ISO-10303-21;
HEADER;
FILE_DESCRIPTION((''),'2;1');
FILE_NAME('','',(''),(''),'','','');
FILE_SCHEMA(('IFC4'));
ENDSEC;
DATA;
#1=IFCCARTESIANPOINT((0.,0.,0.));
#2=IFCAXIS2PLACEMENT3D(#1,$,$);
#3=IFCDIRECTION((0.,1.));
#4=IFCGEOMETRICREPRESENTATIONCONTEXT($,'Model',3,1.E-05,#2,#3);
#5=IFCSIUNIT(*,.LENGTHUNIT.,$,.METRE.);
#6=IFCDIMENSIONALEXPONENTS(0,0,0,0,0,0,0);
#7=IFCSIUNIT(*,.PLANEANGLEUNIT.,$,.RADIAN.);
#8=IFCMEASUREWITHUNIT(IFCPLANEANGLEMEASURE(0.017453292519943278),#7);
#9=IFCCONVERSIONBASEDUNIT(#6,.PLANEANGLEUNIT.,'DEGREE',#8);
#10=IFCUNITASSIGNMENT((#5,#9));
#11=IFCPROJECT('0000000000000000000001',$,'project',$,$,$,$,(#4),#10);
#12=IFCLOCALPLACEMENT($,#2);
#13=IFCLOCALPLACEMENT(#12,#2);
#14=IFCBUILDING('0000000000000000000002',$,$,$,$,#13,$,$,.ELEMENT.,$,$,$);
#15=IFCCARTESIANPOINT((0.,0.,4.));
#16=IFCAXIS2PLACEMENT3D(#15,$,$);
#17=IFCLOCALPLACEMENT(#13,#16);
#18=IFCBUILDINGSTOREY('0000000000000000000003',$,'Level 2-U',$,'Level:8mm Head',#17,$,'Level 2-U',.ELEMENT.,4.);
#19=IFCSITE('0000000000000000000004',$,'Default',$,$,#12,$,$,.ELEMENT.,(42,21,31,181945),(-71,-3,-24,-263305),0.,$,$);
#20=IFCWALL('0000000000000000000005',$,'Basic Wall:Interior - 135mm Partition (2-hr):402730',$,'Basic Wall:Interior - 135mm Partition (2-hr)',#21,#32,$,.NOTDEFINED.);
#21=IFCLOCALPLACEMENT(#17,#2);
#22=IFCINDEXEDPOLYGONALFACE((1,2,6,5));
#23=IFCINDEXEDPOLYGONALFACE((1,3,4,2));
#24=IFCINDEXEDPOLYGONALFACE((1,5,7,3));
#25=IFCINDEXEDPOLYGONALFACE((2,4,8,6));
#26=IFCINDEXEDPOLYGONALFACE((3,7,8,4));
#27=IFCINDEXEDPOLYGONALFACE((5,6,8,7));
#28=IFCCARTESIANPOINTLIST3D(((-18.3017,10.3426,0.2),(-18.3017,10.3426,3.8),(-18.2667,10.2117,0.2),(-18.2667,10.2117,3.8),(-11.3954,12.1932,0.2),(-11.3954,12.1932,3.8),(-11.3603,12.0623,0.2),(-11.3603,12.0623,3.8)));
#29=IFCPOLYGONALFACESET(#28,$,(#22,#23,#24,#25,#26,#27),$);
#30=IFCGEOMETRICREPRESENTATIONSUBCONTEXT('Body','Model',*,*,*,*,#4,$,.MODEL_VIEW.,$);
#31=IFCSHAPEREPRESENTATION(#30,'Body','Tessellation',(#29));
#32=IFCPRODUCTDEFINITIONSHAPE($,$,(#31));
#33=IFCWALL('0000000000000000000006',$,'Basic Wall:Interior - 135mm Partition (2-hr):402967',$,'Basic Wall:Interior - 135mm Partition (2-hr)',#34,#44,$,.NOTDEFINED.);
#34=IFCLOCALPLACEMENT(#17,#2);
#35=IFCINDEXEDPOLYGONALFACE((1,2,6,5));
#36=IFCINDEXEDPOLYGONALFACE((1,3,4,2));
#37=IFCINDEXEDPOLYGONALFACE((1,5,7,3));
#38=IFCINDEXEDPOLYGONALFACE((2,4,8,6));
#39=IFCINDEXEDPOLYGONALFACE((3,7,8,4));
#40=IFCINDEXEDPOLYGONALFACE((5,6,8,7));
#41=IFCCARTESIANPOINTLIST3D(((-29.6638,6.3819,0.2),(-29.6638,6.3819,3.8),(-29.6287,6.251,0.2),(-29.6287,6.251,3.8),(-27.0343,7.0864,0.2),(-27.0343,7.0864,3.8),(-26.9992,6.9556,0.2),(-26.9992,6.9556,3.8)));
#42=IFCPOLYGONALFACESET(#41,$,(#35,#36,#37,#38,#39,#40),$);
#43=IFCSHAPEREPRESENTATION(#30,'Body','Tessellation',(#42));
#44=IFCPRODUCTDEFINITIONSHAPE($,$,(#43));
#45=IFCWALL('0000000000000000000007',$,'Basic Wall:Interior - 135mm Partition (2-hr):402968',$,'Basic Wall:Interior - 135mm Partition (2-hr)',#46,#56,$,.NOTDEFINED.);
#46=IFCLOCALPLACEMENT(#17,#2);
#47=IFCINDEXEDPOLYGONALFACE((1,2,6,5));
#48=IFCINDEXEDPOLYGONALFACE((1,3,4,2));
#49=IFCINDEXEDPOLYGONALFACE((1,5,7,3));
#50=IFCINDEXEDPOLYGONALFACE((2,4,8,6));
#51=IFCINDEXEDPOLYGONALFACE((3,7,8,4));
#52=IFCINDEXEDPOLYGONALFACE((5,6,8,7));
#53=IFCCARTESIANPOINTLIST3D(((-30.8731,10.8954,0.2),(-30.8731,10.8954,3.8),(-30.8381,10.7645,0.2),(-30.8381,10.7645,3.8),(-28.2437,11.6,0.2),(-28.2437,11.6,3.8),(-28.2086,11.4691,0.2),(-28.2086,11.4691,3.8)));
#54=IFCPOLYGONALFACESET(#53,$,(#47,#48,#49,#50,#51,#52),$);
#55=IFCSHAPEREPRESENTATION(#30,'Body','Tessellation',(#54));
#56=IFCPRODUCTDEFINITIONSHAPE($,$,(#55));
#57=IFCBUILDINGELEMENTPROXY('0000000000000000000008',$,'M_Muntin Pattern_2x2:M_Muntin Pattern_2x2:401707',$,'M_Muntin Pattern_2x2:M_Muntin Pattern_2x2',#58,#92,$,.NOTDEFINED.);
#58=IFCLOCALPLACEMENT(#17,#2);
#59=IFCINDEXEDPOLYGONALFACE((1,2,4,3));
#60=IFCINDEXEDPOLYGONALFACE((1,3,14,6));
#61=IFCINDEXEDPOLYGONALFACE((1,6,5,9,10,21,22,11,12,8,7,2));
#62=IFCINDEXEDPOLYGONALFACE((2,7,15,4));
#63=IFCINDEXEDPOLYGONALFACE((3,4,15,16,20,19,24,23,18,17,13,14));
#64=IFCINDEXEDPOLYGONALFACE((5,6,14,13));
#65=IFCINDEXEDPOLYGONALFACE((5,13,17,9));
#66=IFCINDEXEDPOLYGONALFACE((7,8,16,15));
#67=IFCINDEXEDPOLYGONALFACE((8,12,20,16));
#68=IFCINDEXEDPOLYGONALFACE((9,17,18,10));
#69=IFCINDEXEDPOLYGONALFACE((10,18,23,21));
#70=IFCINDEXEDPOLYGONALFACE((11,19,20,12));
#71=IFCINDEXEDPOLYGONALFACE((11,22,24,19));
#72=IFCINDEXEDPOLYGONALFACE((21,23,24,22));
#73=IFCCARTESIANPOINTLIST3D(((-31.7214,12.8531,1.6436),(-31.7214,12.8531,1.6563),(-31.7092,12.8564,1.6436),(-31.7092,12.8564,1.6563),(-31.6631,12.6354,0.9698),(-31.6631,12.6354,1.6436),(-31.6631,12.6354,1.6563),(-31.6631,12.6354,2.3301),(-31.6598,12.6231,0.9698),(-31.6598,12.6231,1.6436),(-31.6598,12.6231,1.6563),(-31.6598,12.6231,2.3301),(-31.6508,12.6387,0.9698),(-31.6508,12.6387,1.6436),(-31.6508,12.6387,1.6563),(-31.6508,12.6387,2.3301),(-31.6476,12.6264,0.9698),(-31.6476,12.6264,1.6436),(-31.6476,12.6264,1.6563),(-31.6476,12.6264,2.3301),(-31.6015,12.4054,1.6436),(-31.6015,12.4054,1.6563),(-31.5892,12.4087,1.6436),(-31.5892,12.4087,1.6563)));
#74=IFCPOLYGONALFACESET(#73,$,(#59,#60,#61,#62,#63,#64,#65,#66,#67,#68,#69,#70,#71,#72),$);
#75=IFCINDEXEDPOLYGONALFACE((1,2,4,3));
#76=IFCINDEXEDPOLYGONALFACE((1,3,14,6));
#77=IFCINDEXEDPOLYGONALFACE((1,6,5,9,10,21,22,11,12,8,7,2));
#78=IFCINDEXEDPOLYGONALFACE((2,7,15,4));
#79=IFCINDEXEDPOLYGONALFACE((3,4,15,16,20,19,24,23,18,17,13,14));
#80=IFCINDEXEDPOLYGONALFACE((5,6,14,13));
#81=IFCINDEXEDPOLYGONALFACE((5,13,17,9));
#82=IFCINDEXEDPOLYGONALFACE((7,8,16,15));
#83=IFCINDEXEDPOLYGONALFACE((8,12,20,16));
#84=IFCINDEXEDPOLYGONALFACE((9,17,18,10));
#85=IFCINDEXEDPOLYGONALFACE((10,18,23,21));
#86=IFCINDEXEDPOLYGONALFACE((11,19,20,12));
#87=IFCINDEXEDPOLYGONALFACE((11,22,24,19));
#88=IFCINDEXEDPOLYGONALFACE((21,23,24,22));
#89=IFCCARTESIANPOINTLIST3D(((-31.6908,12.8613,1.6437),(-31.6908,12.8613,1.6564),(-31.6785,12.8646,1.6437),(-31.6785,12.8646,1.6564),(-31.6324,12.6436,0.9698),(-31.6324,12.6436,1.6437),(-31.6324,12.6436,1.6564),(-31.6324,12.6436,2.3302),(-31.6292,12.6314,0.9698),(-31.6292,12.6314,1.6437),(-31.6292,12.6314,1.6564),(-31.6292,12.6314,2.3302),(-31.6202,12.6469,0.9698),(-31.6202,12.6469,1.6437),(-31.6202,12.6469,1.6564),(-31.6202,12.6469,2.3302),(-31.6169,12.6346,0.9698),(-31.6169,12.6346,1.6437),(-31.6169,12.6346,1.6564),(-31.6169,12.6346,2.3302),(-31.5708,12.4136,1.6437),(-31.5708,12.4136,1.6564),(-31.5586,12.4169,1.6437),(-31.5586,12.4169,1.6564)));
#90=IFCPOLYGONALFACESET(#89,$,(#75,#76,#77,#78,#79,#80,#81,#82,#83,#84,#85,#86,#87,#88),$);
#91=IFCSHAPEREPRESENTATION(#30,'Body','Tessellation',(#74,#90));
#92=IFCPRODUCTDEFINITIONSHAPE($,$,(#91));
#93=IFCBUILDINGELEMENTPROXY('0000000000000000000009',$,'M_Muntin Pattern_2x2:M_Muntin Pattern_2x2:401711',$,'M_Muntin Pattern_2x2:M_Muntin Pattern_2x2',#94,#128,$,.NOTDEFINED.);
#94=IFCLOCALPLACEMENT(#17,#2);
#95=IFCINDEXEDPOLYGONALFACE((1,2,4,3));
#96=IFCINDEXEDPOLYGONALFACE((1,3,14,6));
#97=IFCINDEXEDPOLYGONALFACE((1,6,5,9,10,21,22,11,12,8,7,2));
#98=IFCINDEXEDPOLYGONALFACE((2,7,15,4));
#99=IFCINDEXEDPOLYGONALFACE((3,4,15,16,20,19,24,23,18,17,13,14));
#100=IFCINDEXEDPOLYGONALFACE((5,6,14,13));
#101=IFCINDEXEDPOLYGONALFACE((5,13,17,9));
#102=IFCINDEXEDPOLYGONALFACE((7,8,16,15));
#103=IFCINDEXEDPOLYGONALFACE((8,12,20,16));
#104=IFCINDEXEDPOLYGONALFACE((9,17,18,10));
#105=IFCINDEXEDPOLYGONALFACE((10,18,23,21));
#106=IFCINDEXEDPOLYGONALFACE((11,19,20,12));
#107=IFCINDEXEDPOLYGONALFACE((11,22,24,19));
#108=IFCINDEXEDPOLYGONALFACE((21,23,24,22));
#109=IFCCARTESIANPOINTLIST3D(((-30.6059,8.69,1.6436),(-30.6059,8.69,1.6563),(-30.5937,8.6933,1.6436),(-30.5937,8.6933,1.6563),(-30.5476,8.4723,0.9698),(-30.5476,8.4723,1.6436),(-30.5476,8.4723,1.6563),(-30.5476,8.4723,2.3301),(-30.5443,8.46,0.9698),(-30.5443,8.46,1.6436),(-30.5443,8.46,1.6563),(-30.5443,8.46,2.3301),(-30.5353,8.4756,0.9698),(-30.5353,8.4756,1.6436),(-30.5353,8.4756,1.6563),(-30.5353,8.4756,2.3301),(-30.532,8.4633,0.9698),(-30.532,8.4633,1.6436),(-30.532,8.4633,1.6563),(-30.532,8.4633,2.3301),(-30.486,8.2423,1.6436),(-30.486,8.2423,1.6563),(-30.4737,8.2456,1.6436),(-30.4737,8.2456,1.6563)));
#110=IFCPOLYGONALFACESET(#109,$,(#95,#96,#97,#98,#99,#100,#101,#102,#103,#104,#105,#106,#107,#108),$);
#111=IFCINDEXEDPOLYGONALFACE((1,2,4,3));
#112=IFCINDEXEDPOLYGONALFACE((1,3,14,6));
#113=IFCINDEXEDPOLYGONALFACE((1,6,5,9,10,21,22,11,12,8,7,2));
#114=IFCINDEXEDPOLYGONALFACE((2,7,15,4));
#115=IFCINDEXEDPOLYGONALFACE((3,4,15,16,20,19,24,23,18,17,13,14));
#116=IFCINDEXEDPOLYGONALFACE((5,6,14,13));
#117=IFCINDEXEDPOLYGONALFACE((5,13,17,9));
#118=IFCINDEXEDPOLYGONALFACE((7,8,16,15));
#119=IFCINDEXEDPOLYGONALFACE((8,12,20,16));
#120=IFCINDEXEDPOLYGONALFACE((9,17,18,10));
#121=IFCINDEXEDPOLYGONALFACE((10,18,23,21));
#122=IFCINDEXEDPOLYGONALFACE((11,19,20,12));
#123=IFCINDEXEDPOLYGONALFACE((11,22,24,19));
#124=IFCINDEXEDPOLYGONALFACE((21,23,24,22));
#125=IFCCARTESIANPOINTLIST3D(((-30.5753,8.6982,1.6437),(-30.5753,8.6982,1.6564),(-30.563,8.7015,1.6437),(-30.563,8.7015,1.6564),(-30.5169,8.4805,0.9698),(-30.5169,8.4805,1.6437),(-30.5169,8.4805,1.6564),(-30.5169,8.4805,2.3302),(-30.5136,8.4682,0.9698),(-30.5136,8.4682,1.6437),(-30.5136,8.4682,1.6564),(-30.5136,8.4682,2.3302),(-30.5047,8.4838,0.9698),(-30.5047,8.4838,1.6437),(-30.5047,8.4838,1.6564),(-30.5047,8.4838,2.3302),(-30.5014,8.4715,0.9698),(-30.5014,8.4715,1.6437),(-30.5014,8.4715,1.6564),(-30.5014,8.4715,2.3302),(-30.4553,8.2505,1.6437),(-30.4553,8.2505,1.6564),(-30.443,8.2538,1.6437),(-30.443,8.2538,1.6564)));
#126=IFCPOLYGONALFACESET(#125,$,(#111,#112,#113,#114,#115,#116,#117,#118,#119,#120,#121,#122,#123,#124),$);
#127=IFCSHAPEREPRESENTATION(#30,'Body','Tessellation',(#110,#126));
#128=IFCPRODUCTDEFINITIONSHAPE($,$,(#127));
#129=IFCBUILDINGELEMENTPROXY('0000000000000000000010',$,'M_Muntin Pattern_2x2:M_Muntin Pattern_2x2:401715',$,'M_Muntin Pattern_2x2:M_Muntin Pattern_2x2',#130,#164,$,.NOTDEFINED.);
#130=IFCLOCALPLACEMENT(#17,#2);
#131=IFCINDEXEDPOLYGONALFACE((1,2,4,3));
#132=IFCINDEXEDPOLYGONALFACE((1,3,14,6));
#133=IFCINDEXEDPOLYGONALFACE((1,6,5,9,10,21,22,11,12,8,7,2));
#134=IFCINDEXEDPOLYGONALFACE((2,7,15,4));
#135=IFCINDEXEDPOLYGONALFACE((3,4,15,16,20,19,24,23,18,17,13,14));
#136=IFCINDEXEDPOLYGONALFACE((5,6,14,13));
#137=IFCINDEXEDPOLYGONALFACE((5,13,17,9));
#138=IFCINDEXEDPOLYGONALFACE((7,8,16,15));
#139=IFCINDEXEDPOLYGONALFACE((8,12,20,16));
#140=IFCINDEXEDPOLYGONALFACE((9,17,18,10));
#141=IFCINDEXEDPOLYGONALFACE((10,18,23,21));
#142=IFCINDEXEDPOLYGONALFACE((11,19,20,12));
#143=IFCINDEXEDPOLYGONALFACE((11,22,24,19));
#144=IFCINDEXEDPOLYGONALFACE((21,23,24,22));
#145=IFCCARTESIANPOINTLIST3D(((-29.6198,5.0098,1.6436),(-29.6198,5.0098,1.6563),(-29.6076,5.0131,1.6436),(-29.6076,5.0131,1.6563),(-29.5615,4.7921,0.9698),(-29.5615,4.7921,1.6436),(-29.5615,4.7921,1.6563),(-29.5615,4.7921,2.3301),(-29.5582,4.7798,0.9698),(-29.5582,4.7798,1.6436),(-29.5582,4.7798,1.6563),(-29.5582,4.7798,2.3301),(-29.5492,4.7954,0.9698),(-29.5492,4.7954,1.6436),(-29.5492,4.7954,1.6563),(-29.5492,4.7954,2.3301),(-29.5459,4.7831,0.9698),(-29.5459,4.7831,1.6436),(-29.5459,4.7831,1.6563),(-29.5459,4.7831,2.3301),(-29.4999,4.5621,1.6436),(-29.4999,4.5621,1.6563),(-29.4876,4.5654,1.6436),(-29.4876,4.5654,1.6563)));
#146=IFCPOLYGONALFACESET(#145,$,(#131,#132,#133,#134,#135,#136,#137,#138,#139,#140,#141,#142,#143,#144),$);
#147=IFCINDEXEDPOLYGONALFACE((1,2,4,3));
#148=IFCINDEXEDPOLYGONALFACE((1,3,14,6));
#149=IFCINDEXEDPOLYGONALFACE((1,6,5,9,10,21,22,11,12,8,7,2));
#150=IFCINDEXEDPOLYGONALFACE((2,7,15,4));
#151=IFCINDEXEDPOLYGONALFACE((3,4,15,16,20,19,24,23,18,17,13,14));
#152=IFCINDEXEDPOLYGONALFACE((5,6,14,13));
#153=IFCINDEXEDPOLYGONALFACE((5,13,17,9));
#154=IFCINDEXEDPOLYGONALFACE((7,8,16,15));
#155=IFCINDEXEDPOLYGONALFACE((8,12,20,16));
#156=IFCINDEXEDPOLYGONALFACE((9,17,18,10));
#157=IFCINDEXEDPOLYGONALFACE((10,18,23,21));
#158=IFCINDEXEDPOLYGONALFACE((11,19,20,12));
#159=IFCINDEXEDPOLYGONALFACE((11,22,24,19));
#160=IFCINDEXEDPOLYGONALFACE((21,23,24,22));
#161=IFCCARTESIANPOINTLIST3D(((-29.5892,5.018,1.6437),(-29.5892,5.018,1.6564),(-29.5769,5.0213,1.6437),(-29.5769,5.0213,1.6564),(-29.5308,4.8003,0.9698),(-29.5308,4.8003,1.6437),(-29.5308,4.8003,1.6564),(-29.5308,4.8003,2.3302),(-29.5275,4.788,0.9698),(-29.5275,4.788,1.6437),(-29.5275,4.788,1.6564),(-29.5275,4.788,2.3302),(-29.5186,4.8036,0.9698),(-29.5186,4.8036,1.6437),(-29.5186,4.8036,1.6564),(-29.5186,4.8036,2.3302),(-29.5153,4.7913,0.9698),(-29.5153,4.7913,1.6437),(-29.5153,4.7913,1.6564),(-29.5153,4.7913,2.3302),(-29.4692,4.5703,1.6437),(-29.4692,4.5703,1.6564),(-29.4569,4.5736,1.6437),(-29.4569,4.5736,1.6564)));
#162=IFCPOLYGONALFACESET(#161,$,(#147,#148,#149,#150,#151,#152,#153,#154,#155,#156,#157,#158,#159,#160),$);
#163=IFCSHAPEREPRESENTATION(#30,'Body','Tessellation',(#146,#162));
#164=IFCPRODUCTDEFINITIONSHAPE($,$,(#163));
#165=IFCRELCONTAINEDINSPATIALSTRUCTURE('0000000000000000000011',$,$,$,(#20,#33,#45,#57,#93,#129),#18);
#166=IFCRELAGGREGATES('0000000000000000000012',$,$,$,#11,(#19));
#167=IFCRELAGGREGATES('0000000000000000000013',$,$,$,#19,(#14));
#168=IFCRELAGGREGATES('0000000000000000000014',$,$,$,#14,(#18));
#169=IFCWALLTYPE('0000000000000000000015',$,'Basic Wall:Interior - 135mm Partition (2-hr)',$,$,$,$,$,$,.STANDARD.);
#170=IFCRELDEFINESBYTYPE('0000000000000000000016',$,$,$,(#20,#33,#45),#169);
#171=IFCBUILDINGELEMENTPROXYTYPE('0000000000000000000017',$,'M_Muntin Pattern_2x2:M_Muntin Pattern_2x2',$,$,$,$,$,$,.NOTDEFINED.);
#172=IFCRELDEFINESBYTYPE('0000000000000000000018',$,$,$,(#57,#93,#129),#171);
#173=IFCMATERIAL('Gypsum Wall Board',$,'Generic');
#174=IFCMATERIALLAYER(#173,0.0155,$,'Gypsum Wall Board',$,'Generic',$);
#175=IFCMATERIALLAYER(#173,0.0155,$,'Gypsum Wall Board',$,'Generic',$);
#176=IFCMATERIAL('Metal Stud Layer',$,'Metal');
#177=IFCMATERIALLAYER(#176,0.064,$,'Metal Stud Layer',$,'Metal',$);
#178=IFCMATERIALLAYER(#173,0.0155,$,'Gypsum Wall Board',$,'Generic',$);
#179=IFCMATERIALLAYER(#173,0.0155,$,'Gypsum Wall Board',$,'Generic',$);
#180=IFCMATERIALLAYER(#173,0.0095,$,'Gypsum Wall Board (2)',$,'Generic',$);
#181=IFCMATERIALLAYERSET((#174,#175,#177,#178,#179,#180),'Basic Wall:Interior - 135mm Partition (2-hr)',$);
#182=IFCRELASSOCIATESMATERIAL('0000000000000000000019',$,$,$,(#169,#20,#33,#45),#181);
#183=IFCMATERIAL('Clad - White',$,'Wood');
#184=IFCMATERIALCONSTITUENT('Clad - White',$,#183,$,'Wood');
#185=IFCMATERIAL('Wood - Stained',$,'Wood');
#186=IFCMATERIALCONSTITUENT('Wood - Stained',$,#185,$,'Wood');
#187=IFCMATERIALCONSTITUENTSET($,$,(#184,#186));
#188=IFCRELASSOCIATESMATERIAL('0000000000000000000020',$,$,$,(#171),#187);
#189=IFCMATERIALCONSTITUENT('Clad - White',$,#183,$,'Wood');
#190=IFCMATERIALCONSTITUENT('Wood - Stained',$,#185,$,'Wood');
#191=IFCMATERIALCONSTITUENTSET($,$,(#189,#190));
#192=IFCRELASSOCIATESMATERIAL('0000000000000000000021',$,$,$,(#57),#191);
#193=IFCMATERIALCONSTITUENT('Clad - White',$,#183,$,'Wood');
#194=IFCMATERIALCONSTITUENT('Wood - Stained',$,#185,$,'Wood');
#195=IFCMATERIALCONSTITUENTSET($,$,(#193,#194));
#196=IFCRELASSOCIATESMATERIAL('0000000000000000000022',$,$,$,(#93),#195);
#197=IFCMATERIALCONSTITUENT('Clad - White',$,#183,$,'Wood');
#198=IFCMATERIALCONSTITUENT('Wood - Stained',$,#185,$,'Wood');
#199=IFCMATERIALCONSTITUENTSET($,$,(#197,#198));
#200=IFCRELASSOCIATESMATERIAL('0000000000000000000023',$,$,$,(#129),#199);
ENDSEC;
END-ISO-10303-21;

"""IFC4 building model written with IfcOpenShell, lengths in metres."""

from ifc_helpers import new_model, entity, si_unit, converted_unit, direction, frame, frame_2d, origin, place, context, subcontext, project, spatial, polyline, rectangle, outline, extrude, source, transform, mapped, material, layer, layer_set, layer_usage, constituent, constituent_set, type_object, type_shapes, element, save


model = new_model("IFC4")

# Units and contexts
model_context = context("Model", 3, precision=1e-05, world=origin(), true_north=direction((0.0, 1.0)))
body_context = subcontext(model_context, "Body", "Model", "MODEL_VIEW")
ifc_project = project(units=[si_unit("LENGTHUNIT", "METRE"), converted_unit("PLANEANGLEUNIT", "DEGREE", entity("IfcPlaneAngleMeasure", 0.017453292519943278), si_unit("PLANEANGLEUNIT", "RADIAN"), dimensions=[0, 0, 0, 0, 0, 0, 0])], contexts=[model_context])

# Site, building, storey
site_placement = place(None, origin())
site = spatial("IfcSite", under=ifc_project, at=site_placement, Name="Default", CompositionType="ELEMENT", RefLatitude=(42, 21, 31, 181945), RefLongitude=(-71, -3, -24, -263305), RefElevation=0.0)
building_placement = place(site_placement, origin())
building = spatial("IfcBuilding", under=site, at=building_placement, CompositionType="ELEMENT")
storey_placement = place(building_placement, frame((0.0, 0.0, 4.0)))
storey = spatial("IfcBuildingStorey", under=building, at=storey_placement, Name="Level 2-U", ObjectType="Level:8mm Head", LongName="Level 2-U", CompositionType="ELEMENT", Elevation=4.0)

# Shared definitions
ifc_material_1 = material(Name="Gypsum Wall Board", Category="Generic")
ifc_layer_1 = layer(ifc_material_1, 0.0155, Name="Gypsum Wall Board", Category="Generic")
ifc_layer_2 = layer(ifc_material_1, 0.0155, Name="Gypsum Wall Board", Category="Generic")
ifc_material_2 = material(Name="Metal Stud Layer", Category="Metal")
ifc_layer_3 = layer(ifc_material_2, 0.064, Name="Metal Stud Layer", Category="Metal")
ifc_layer_4 = layer(ifc_material_1, 0.0155, Name="Gypsum Wall Board", Category="Generic")
ifc_layer_5 = layer(ifc_material_1, 0.0155, Name="Gypsum Wall Board", Category="Generic")
ifc_layer_6 = layer(ifc_material_1, 0.0095, Name="Gypsum Wall Board (2)", Category="Generic")
ifc_layer_set_1 = layer_set([ifc_layer_1, ifc_layer_2, ifc_layer_3, ifc_layer_4, ifc_layer_5, ifc_layer_6], Name="Basic Wall:Interior - 135mm Partition (2-hr)")
ifc_layer_usage_1 = layer_usage(ifc_layer_set_1, "AXIS2", "NEGATIVE", 0.0677)
wall_type_1 = type_object("IfcWallType", Name="Basic Wall:Interior - 135mm Partition (2-hr)", PredefinedType="STANDARD", material=ifc_layer_set_1)

# Walls
wall_1_placement = place(storey_placement, frame((-11.3778, 12.1277, 0.2), z_axis=(0.0, 0.0, 1.0), x_axis=(-0.965926, -0.258819, 0.0)))
element("IfcWall", 1, at=wall_1_placement, inside=storey, type_object=wall_type_1, material=ifc_layer_usage_1, Name="Basic Wall:Interior - 135mm Partition (2-hr):402730", ObjectType="Basic Wall:Interior - 135mm Partition (2-hr)", PredefinedType="NOTDEFINED", context=body_context, shape_type="SweptSolid", body=[
    extrude(rectangle(XDim=7.15, YDim=0.1355, at=frame_2d((3.575, 0.0), x_axis=(-1.0, 0.0))), origin(), (0.0, 0.0, 1.0), 3.6),
])
wall_2_placement = place(storey_placement, frame((-29.6462, 6.3164, 0.2), z_axis=(0.0, 0.0, 1.0), x_axis=(0.965926, 0.258819, 0.0)))
element("IfcWall", 2, at=wall_2_placement, inside=storey, type_object=wall_type_1, material=ifc_layer_usage_1, Name="Basic Wall:Interior - 135mm Partition (2-hr):402967", ObjectType="Basic Wall:Interior - 135mm Partition (2-hr)", PredefinedType="NOTDEFINED", context=body_context, shape_type="SweptSolid", body=[
    extrude(rectangle(XDim=2.7222, YDim=0.1355, at=frame_2d((1.3611, 0.0), x_axis=(-1.0, 0.0))), origin(), (0.0, 0.0, 1.0), 3.6),
])
wall_3_placement = place(storey_placement, frame((-28.2261, 11.5345, 0.2), z_axis=(0.0, 0.0, 1.0), x_axis=(-0.965926, -0.258819, 0.0)))
element("IfcWall", 3, at=wall_3_placement, inside=storey, type_object=wall_type_1, material=ifc_layer_usage_1, Name="Basic Wall:Interior - 135mm Partition (2-hr):402968", ObjectType="Basic Wall:Interior - 135mm Partition (2-hr)", PredefinedType="NOTDEFINED", context=body_context, shape_type="SweptSolid", body=[
    extrude(rectangle(XDim=2.7222, YDim=0.1355, at=frame_2d((1.3611, 0.0), x_axis=(-1.0, 0.0))), origin(), (0.0, 0.0, 1.0), 3.6),
])

# Building element proxies
ifc_material_3 = material(Name="Clad - White", Category="Wood")
ifc_constituent_1 = constituent(ifc_material_3, Name="Clad - White", Category="Wood")
ifc_material_4 = material(Name="Wood - Stained", Category="Wood")
ifc_constituent_2 = constituent(ifc_material_4, Name="Wood - Stained", Category="Wood")
ifc_constituent_set_1 = constituent_set(constituents=[ifc_constituent_1, ifc_constituent_2])
ifc_constituent_3 = constituent(ifc_material_3, Name="Clad - White", Category="Wood")
ifc_constituent_4 = constituent(ifc_material_4, Name="Wood - Stained", Category="Wood")
ifc_constituent_set_2 = constituent_set(constituents=[ifc_constituent_3, ifc_constituent_4])
building_element_proxy_type_1 = type_object("IfcBuildingElementProxyType", Name="M_Muntin Pattern_2x2:M_Muntin Pattern_2x2", PredefinedType="NOTDEFINED", material=ifc_constituent_set_2)
shared_shape_1 = source(origin(), body_context, "Body", "SweptSolid", [
    extrude(outline(polyline([(0.0064, -0.0064), (0.6801, -0.0064), (0.6801, 0.0063), (0.0064, 0.0063), (0.0064, 0.2317), (-0.0063, 0.2317), (-0.0063, 0.0063), (-0.6802, 0.0063), (-0.6802, -0.0064), (-0.0063, -0.0064), (-0.0063, -0.2317), (0.0064, -0.2317), (0.0064, -0.0064)])), frame((0.0, 0.0095, 0.6801), z_axis=(0.0, 1.0, 0.0), x_axis=(0.0, 0.0, 1.0)), (0.0, 0.0, 1.0), 0.0127),
    extrude(outline(polyline([(0.0064, -0.0064), (0.6802, -0.0064), (0.6802, 0.0063), (0.0064, 0.0063), (0.0064, 0.2317), (-0.0063, 0.2317), (-0.0063, 0.0063), (-0.6802, 0.0063), (-0.6802, -0.0064), (-0.0063, -0.0064), (-0.0063, -0.2317), (0.0064, -0.2317), (0.0064, -0.0064)])), frame((0.0, -0.0222, 0.6802), z_axis=(0.0, 1.0, 0.0), x_axis=(0.0, 0.0, 1.0)), (0.0, 0.0, 1.0), 0.0127),
])
type_shapes(building_element_proxy_type_1, [shared_shape_1])
proxy_1_placement = place(storey_placement, frame((-31.64, 12.635, 0.9698), z_axis=(0.0, 0.0, 1.0), x_axis=(-0.258819, 0.965926, 0.0)))
element("IfcBuildingElementProxy", 4, at=proxy_1_placement, inside=storey, type_object=building_element_proxy_type_1, material=ifc_constituent_set_1, Name="M_Muntin Pattern_2x2:M_Muntin Pattern_2x2:401707", ObjectType="M_Muntin Pattern_2x2:M_Muntin Pattern_2x2", PredefinedType="NOTDEFINED", context=body_context, shape_type="MappedRepresentation", body=[
    mapped(shared_shape_1, transform((0.0, 0.0, 0.0), scale=1.0)),
])
ifc_constituent_5 = constituent(ifc_material_3, Name="Clad - White", Category="Wood")
ifc_constituent_6 = constituent(ifc_material_4, Name="Wood - Stained", Category="Wood")
ifc_constituent_set_3 = constituent_set(constituents=[ifc_constituent_5, ifc_constituent_6])
proxy_2_placement = place(storey_placement, frame((-30.5245, 8.4719, 0.9698), z_axis=(0.0, 0.0, 1.0), x_axis=(-0.258819, 0.965926, 0.0)))
element("IfcBuildingElementProxy", 5, at=proxy_2_placement, inside=storey, type_object=building_element_proxy_type_1, material=ifc_constituent_set_3, Name="M_Muntin Pattern_2x2:M_Muntin Pattern_2x2:401711", ObjectType="M_Muntin Pattern_2x2:M_Muntin Pattern_2x2", PredefinedType="NOTDEFINED", context=body_context, shape_type="MappedRepresentation", body=[
    mapped(shared_shape_1, transform((0.0, 0.0, 0.0), scale=1.0)),
])
ifc_constituent_7 = constituent(ifc_material_3, Name="Clad - White", Category="Wood")
ifc_constituent_8 = constituent(ifc_material_4, Name="Wood - Stained", Category="Wood")
ifc_constituent_set_4 = constituent_set(constituents=[ifc_constituent_7, ifc_constituent_8])
proxy_3_placement = place(storey_placement, frame((-29.5384, 4.7917, 0.9698), z_axis=(0.0, 0.0, 1.0), x_axis=(-0.258819, 0.965926, 0.0)))
element("IfcBuildingElementProxy", 6, at=proxy_3_placement, inside=storey, type_object=building_element_proxy_type_1, material=ifc_constituent_set_4, Name="M_Muntin Pattern_2x2:M_Muntin Pattern_2x2:401715", ObjectType="M_Muntin Pattern_2x2:M_Muntin Pattern_2x2", PredefinedType="NOTDEFINED", context=body_context, shape_type="MappedRepresentation", body=[
    mapped(shared_shape_1, transform((0.0, 0.0, 0.0), scale=1.0)),
])

save(model, "model.ifc")
